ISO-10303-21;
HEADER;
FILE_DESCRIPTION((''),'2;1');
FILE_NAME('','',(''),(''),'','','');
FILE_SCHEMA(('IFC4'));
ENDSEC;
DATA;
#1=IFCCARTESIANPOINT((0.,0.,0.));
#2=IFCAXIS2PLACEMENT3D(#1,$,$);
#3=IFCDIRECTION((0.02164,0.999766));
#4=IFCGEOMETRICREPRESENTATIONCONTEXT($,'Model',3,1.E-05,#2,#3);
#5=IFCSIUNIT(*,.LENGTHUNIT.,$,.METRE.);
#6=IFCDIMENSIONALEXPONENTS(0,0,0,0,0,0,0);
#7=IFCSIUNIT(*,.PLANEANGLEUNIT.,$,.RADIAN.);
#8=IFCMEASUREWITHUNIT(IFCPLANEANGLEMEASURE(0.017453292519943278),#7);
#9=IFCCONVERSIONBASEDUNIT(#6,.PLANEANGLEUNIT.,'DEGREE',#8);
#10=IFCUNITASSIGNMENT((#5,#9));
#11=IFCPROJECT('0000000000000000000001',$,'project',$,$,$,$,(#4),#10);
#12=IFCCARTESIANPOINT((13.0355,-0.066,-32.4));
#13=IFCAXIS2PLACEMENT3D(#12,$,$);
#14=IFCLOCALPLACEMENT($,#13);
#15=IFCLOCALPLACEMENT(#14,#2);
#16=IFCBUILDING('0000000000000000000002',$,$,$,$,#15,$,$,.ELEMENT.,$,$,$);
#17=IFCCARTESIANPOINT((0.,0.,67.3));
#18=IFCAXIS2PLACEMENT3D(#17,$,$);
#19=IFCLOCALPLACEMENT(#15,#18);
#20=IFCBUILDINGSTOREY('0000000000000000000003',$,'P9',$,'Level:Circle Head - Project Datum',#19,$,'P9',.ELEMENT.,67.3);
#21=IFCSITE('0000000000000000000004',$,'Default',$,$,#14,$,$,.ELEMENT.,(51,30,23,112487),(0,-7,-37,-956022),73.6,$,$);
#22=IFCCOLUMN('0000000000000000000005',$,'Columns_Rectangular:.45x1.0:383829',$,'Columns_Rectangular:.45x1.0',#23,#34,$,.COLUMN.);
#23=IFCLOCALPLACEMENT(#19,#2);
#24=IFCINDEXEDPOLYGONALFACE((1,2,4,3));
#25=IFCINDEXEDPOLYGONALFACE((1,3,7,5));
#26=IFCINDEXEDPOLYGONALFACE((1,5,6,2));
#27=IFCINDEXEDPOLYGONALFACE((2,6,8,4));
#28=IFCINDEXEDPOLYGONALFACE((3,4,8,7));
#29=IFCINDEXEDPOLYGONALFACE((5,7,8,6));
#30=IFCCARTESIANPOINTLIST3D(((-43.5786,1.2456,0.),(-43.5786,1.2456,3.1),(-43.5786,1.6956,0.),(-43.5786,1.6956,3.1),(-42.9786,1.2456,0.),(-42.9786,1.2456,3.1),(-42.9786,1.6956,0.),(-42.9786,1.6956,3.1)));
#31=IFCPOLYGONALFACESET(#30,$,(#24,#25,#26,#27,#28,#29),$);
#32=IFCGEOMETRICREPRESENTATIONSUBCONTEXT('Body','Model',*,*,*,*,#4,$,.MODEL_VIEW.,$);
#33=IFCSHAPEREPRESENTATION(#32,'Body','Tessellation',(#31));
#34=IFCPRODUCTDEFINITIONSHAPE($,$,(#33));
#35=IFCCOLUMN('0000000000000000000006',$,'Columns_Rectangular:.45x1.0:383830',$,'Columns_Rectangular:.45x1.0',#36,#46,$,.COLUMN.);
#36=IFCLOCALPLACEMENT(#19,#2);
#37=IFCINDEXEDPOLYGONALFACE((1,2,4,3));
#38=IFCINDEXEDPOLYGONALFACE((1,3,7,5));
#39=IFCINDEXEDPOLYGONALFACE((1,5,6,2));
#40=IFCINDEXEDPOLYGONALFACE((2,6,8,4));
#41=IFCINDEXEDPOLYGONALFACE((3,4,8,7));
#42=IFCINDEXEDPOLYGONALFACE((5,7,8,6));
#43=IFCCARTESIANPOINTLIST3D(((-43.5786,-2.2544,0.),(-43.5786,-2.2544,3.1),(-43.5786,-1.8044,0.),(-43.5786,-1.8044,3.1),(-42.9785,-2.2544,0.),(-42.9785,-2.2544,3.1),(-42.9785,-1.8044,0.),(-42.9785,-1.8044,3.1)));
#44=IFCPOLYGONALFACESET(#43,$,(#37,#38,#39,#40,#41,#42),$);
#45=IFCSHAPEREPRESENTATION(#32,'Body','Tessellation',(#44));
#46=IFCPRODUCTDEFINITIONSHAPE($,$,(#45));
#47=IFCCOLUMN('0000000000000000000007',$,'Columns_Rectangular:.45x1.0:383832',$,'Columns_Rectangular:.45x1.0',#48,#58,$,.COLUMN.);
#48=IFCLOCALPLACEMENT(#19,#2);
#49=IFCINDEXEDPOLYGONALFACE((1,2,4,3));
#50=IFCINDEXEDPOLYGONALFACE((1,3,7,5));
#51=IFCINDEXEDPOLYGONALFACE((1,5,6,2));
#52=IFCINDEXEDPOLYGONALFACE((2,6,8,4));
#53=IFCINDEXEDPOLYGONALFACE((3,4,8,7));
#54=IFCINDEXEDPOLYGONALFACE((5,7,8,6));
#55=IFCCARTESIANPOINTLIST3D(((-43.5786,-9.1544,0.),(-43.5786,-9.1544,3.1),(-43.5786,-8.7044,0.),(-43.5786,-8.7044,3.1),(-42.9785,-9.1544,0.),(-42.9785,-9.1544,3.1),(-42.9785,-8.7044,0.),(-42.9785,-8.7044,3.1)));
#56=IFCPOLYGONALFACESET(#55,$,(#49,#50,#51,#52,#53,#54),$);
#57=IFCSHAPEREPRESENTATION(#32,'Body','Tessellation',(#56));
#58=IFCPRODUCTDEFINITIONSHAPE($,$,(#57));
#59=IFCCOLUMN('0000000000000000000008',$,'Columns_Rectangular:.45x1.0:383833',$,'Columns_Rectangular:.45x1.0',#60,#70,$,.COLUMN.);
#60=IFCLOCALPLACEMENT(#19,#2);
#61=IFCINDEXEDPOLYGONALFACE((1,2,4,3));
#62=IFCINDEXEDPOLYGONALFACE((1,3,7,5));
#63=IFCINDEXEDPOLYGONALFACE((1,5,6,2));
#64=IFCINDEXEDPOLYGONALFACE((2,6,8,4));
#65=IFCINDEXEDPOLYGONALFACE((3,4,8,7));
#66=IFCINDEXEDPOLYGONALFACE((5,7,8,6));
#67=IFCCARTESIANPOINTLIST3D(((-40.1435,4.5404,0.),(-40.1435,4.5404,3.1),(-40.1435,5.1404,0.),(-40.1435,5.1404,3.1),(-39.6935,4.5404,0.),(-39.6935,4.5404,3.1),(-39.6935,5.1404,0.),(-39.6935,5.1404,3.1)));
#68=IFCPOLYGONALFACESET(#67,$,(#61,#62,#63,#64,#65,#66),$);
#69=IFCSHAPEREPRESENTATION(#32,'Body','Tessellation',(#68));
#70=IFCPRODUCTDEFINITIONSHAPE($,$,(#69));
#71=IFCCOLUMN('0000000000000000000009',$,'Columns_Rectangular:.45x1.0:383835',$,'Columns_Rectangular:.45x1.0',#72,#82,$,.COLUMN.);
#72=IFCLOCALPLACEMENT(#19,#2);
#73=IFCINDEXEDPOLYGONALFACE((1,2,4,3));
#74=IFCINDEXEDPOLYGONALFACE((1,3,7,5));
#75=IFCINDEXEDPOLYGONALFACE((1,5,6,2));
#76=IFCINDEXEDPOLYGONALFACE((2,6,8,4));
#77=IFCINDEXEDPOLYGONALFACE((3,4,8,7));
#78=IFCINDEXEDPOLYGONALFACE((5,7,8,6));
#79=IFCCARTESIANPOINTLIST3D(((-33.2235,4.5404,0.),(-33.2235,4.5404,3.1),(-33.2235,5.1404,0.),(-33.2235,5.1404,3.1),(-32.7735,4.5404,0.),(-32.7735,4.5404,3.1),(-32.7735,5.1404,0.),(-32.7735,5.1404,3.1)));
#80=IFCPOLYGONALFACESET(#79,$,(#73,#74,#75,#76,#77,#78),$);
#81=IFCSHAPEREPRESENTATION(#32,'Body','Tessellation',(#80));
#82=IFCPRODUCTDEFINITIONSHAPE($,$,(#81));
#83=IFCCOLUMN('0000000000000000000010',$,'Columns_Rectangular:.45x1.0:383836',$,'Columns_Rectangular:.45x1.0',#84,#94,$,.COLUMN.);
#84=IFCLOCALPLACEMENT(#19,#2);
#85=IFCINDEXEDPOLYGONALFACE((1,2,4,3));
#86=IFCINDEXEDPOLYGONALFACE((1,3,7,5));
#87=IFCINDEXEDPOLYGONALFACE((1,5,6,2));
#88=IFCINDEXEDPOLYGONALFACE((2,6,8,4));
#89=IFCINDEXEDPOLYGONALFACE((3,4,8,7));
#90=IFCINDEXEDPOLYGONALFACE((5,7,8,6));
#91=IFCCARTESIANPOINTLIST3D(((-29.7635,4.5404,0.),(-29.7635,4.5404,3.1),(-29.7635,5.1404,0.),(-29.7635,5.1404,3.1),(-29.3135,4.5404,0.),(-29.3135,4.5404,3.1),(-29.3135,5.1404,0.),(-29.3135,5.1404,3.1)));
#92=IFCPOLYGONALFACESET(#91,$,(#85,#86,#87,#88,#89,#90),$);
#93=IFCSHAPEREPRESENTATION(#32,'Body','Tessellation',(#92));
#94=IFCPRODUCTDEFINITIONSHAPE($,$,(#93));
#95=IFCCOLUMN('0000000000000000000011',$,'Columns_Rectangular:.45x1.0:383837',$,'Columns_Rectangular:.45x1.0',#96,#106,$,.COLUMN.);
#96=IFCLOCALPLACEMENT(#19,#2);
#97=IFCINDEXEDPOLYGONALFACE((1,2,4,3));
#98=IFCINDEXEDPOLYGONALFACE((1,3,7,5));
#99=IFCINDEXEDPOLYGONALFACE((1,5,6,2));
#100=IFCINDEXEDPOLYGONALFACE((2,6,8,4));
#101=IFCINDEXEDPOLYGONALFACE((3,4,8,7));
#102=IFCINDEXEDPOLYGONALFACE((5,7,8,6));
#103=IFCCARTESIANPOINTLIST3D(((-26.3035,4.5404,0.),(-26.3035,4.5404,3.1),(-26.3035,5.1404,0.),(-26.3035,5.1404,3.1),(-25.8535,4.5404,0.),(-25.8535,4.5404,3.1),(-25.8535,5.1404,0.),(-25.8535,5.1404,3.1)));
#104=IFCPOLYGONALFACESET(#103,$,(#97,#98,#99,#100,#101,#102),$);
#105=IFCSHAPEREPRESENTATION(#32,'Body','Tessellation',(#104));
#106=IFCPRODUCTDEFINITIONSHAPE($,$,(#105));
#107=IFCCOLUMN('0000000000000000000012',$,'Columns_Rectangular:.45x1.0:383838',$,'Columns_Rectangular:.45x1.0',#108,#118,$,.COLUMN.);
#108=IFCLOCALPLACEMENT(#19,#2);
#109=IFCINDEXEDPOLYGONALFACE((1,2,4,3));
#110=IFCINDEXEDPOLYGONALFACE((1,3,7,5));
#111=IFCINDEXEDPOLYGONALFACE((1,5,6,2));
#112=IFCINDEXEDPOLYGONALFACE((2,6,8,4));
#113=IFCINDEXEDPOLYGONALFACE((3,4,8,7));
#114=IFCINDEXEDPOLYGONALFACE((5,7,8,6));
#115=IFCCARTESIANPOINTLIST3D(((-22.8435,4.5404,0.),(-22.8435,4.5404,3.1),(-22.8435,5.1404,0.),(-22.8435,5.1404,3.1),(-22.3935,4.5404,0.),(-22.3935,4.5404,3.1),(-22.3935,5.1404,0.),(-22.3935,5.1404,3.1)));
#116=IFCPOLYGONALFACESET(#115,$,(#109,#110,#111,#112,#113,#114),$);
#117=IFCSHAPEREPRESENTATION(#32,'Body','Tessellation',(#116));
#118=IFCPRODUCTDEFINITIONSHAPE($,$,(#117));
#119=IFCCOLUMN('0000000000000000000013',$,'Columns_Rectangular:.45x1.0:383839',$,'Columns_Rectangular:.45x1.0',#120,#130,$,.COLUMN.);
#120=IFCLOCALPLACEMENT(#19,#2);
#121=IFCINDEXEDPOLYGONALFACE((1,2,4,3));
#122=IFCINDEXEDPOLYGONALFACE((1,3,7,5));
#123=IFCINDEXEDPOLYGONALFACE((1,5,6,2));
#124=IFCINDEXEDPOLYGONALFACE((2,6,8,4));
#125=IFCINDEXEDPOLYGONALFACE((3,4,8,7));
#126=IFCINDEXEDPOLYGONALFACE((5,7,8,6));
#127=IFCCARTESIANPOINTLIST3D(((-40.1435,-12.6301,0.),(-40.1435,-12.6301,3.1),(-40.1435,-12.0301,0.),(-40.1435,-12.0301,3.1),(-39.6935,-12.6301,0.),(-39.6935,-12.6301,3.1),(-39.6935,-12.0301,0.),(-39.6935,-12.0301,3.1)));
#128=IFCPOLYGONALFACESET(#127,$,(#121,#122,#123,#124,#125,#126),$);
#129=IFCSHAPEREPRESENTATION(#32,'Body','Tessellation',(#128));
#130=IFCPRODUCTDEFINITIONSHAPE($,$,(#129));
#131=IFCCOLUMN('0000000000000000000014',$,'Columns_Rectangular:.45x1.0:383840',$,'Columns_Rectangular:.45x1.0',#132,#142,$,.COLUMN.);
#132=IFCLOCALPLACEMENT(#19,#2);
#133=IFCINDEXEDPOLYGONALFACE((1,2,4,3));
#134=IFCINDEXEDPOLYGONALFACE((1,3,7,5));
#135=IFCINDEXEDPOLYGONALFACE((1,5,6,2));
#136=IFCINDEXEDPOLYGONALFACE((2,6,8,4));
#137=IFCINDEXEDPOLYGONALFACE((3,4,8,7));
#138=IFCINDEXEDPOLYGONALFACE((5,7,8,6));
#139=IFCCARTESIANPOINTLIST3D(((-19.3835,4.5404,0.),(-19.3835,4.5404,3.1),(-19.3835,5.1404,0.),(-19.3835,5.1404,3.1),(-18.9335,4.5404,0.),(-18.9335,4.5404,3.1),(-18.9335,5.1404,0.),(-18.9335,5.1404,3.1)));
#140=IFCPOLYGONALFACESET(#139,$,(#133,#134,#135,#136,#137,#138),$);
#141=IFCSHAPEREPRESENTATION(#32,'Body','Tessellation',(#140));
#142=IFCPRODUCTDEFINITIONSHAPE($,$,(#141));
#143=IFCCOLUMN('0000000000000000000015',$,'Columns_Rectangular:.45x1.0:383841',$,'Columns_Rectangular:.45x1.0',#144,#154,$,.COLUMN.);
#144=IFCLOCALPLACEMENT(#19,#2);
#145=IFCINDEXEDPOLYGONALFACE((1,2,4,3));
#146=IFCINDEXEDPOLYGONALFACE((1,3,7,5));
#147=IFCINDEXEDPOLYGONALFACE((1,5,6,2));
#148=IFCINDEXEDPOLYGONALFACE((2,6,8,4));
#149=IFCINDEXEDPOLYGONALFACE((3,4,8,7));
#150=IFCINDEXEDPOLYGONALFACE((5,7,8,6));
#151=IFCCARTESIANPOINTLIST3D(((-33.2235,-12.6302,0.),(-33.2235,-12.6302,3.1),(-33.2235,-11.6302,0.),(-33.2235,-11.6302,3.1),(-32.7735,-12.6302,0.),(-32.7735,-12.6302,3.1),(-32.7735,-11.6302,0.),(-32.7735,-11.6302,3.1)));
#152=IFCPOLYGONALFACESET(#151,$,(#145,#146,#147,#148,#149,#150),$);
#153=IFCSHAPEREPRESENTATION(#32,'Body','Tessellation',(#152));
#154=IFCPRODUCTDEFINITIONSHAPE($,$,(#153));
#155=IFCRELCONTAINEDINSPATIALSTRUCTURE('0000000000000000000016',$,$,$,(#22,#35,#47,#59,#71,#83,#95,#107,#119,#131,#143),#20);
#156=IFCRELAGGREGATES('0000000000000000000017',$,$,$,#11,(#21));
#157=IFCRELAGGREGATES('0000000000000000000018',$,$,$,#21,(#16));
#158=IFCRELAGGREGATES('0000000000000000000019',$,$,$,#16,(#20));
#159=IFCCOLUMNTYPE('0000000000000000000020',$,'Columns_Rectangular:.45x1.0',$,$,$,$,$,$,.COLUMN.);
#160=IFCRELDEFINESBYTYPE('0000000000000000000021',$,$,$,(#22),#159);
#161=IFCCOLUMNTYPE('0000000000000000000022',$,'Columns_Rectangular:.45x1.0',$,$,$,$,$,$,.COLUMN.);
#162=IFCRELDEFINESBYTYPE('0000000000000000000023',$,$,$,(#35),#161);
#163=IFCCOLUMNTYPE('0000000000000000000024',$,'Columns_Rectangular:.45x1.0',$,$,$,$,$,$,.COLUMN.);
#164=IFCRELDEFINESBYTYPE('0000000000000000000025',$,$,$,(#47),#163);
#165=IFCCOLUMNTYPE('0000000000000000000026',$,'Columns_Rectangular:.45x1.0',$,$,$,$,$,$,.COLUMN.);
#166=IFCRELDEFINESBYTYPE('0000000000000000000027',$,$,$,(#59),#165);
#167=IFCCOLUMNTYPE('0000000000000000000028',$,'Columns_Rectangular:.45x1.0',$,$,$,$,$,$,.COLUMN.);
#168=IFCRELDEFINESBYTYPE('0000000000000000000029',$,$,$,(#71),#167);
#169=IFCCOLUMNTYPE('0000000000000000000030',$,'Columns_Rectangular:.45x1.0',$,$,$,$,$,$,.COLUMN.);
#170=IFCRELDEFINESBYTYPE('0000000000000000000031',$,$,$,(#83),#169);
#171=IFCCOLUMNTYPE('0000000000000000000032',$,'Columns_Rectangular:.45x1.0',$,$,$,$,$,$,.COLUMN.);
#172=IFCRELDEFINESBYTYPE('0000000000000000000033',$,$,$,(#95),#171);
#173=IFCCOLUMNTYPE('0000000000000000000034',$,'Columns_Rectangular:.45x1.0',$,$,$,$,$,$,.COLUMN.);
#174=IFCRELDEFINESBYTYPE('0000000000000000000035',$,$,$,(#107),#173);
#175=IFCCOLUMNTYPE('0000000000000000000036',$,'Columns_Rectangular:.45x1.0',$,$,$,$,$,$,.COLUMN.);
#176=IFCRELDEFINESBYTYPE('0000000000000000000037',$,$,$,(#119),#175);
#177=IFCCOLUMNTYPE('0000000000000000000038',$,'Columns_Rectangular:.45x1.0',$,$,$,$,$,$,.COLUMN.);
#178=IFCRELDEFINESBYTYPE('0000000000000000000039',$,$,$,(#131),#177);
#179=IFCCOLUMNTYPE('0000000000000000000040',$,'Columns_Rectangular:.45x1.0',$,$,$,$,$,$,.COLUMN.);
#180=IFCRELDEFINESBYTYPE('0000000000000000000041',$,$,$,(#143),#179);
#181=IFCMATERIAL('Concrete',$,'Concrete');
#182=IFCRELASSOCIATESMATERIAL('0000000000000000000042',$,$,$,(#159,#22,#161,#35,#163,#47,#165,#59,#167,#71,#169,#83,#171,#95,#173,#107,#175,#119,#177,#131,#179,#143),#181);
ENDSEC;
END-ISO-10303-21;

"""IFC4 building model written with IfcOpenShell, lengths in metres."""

from ifc_helpers import new_model, entity, si_unit, converted_unit, direction, frame, origin, place, context, subcontext, project, spatial, indexed_curve, outline, extrude, source, transform, mapped, material, type_object, type_shapes, element, save


model = new_model("IFC4")

# Units and contexts
model_context = context("Model", 3, precision=1e-05, world=origin(), true_north=direction((0.02164, 0.999766)))
body_context = subcontext(model_context, "Body", "Model", "MODEL_VIEW")
ifc_project = project(units=[si_unit("LENGTHUNIT", "METRE"), converted_unit("PLANEANGLEUNIT", "DEGREE", entity("IfcPlaneAngleMeasure", 0.017453292519943278), si_unit("PLANEANGLEUNIT", "RADIAN"), dimensions=[0, 0, 0, 0, 0, 0, 0])], contexts=[model_context])

# Site, building, storey
site_placement = place(None, frame((13.0355, -0.066, -32.4)))
site = spatial("IfcSite", under=ifc_project, at=site_placement, Name="Default", CompositionType="ELEMENT", RefLatitude=(51, 30, 23, 112487), RefLongitude=(0, -7, -37, -956022), RefElevation=73.6)
building_placement = place(site_placement, origin())
building = spatial("IfcBuilding", under=site, at=building_placement, CompositionType="ELEMENT")
storey_placement = place(building_placement, frame((0.0, 0.0, 67.3)))
storey = spatial("IfcBuildingStorey", under=building, at=storey_placement, Name="P9", ObjectType="Level:Circle Head - Project Datum", LongName="P9", CompositionType="ELEMENT", Elevation=67.3)

# Columns
ifc_material = material(Name="Concrete", Category="Concrete")
column_type_1 = type_object("IfcColumnType", Name="Columns_Rectangular:.45x1.0", PredefinedType="COLUMN", material=ifc_material)
shared_shape_1 = source(origin(), body_context, "Body", "SweptSolid", [
    extrude(outline(indexed_curve([(-0.3, -0.225), (0.3, -0.225), (0.3, 0.225), (-0.3, 0.225), (-0.3, -0.225)], self_intersect=False)), frame((-43.2786, 1.4706, 67.3)), (0.0, 0.0, 1.0), 3.1),
])
type_shapes(column_type_1, [shared_shape_1])
column_1_placement = place(storey_placement, frame((0.0, 0.0, -67.3)))
element("IfcColumn", 1, at=column_1_placement, inside=storey, type_object=column_type_1, material=ifc_material, Name="Columns_Rectangular:.45x1.0:383829", ObjectType="Columns_Rectangular:.45x1.0", PredefinedType="COLUMN", context=body_context, shape_type="MappedRepresentation", body=[
    mapped(shared_shape_1, transform((0.0, 0.0, 0.0), scale=1.0)),
])
column_type_2 = type_object("IfcColumnType", Name="Columns_Rectangular:.45x1.0", PredefinedType="COLUMN", material=ifc_material)
shared_shape_2 = source(origin(), body_context, "Body", "SweptSolid", [
    extrude(outline(indexed_curve([(-0.3, -0.225), (0.3, -0.225), (0.3, 0.225), (-0.3, 0.225), (-0.3, -0.225)], self_intersect=False)), frame((-43.2785, -2.0294, 67.3)), (0.0, 0.0, 1.0), 3.1),
])
type_shapes(column_type_2, [shared_shape_2])
column_2_placement = place(storey_placement, frame((0.0, 0.0, -67.3)))
element("IfcColumn", 2, at=column_2_placement, inside=storey, type_object=column_type_2, material=ifc_material, Name="Columns_Rectangular:.45x1.0:383830", ObjectType="Columns_Rectangular:.45x1.0", PredefinedType="COLUMN", context=body_context, shape_type="MappedRepresentation", body=[
    mapped(shared_shape_2, transform((0.0, 0.0, 0.0), scale=1.0)),
])
column_type_3 = type_object("IfcColumnType", Name="Columns_Rectangular:.45x1.0", PredefinedType="COLUMN", material=ifc_material)
shared_shape_3 = source(origin(), body_context, "Body", "SweptSolid", [
    extrude(outline(indexed_curve([(-0.3, -0.225), (0.3, -0.225), (0.3, 0.225), (-0.3, 0.225), (-0.3, -0.225)], self_intersect=False)), frame((-43.2785, -8.9294, 67.3)), (0.0, 0.0, 1.0), 3.1),
])
type_shapes(column_type_3, [shared_shape_3])
column_3_placement = place(storey_placement, frame((0.0, 0.0, -67.3)))
element("IfcColumn", 3, at=column_3_placement, inside=storey, type_object=column_type_3, material=ifc_material, Name="Columns_Rectangular:.45x1.0:383832", ObjectType="Columns_Rectangular:.45x1.0", PredefinedType="COLUMN", context=body_context, shape_type="MappedRepresentation", body=[
    mapped(shared_shape_3, transform((0.0, 0.0, 0.0), scale=1.0)),
])
column_type_4 = type_object("IfcColumnType", Name="Columns_Rectangular:.45x1.0", PredefinedType="COLUMN", material=ifc_material)
shared_shape_4 = source(origin(), body_context, "Body", "SweptSolid", [
    extrude(outline(indexed_curve([(-0.3, -0.225), (0.3, -0.225), (0.3, 0.225), (-0.3, 0.225), (-0.3, -0.225)], self_intersect=False)), frame((-39.9185, 4.8404, 67.3), z_axis=(0.0, 0.0, 1.0), x_axis=(0.0, -1.0, 0.0)), (0.0, 0.0, 1.0), 3.1),
])
type_shapes(column_type_4, [shared_shape_4])
column_4_placement = place(storey_placement, frame((0.0, 0.0, -67.3)))
element("IfcColumn", 4, at=column_4_placement, inside=storey, type_object=column_type_4, material=ifc_material, Name="Columns_Rectangular:.45x1.0:383833", ObjectType="Columns_Rectangular:.45x1.0", PredefinedType="COLUMN", context=body_context, shape_type="MappedRepresentation", body=[
    mapped(shared_shape_4, transform((0.0, 0.0, 0.0), scale=1.0)),
])
column_type_5 = type_object("IfcColumnType", Name="Columns_Rectangular:.45x1.0", PredefinedType="COLUMN", material=ifc_material)
shared_shape_5 = source(origin(), body_context, "Body", "SweptSolid", [
    extrude(outline(indexed_curve([(-0.3, -0.225), (0.3, -0.225), (0.3, 0.225), (-0.3, 0.225), (-0.3, -0.225)], self_intersect=False)), frame((-32.9985, 4.8404, 67.3), z_axis=(0.0, 0.0, 1.0), x_axis=(0.0, -1.0, 0.0)), (0.0, 0.0, 1.0), 3.1),
])
type_shapes(column_type_5, [shared_shape_5])
column_5_placement = place(storey_placement, frame((0.0, 0.0, -67.3)))
element("IfcColumn", 5, at=column_5_placement, inside=storey, type_object=column_type_5, material=ifc_material, Name="Columns_Rectangular:.45x1.0:383835", ObjectType="Columns_Rectangular:.45x1.0", PredefinedType="COLUMN", context=body_context, shape_type="MappedRepresentation", body=[
    mapped(shared_shape_5, transform((0.0, 0.0, 0.0), scale=1.0)),
])
column_type_6 = type_object("IfcColumnType", Name="Columns_Rectangular:.45x1.0", PredefinedType="COLUMN", material=ifc_material)
shared_shape_6 = source(origin(), body_context, "Body", "SweptSolid", [
    extrude(outline(indexed_curve([(-0.3, -0.225), (0.3, -0.225), (0.3, 0.225), (-0.3, 0.225), (-0.3, -0.225)], self_intersect=False)), frame((-29.5385, 4.8404, 67.3), z_axis=(0.0, 0.0, 1.0), x_axis=(0.0, -1.0, 0.0)), (0.0, 0.0, 1.0), 3.1),
])
type_shapes(column_type_6, [shared_shape_6])
column_6_placement = place(storey_placement, frame((0.0, 0.0, -67.3)))
element("IfcColumn", 6, at=column_6_placement, inside=storey, type_object=column_type_6, material=ifc_material, Name="Columns_Rectangular:.45x1.0:383836", ObjectType="Columns_Rectangular:.45x1.0", PredefinedType="COLUMN", context=body_context, shape_type="MappedRepresentation", body=[
    mapped(shared_shape_6, transform((0.0, 0.0, 0.0), scale=1.0)),
])
column_type_7 = type_object("IfcColumnType", Name="Columns_Rectangular:.45x1.0", PredefinedType="COLUMN", material=ifc_material)
shared_shape_7 = source(origin(), body_context, "Body", "SweptSolid", [
    extrude(outline(indexed_curve([(-0.3, -0.225), (0.3, -0.225), (0.3, 0.225), (-0.3, 0.225), (-0.3, -0.225)], self_intersect=False)), frame((-26.0785, 4.8404, 67.3), z_axis=(0.0, 0.0, 1.0), x_axis=(0.0, -1.0, 0.0)), (0.0, 0.0, 1.0), 3.1),
])
type_shapes(column_type_7, [shared_shape_7])
column_7_placement = place(storey_placement, frame((0.0, 0.0, -67.3)))
element("IfcColumn", 7, at=column_7_placement, inside=storey, type_object=column_type_7, material=ifc_material, Name="Columns_Rectangular:.45x1.0:383837", ObjectType="Columns_Rectangular:.45x1.0", PredefinedType="COLUMN", context=body_context, shape_type="MappedRepresentation", body=[
    mapped(shared_shape_7, transform((0.0, 0.0, 0.0), scale=1.0)),
])
column_type_8 = type_object("IfcColumnType", Name="Columns_Rectangular:.45x1.0", PredefinedType="COLUMN", material=ifc_material)
shared_shape_8 = source(origin(), body_context, "Body", "SweptSolid", [
    extrude(outline(indexed_curve([(-0.3, -0.225), (0.3, -0.225), (0.3, 0.225), (-0.3, 0.225), (-0.3, -0.225)], self_intersect=False)), frame((-22.6185, 4.8404, 67.3), z_axis=(0.0, 0.0, 1.0), x_axis=(0.0, -1.0, 0.0)), (0.0, 0.0, 1.0), 3.1),
])
type_shapes(column_type_8, [shared_shape_8])
column_8_placement = place(storey_placement, frame((0.0, 0.0, -67.3)))
element("IfcColumn", 8, at=column_8_placement, inside=storey, type_object=column_type_8, material=ifc_material, Name="Columns_Rectangular:.45x1.0:383838", ObjectType="Columns_Rectangular:.45x1.0", PredefinedType="COLUMN", context=body_context, shape_type="MappedRepresentation", body=[
    mapped(shared_shape_8, transform((0.0, 0.0, 0.0), scale=1.0)),
])
column_type_9 = type_object("IfcColumnType", Name="Columns_Rectangular:.45x1.0", PredefinedType="COLUMN", material=ifc_material)
shared_shape_9 = source(origin(), body_context, "Body", "SweptSolid", [
    extrude(outline(indexed_curve([(-0.3, -0.225), (0.3, -0.225), (0.3, 0.225), (-0.3, 0.225), (-0.3, -0.225)], self_intersect=False)), frame((-39.9185, -12.3301, 67.3), z_axis=(0.0, 0.0, 1.0), x_axis=(0.000011, 1.0, 0.0)), (0.0, 0.0, 1.0), 3.1),
])
type_shapes(column_type_9, [shared_shape_9])
column_9_placement = place(storey_placement, frame((0.0, 0.0, -67.3)))
element("IfcColumn", 9, at=column_9_placement, inside=storey, type_object=column_type_9, material=ifc_material, Name="Columns_Rectangular:.45x1.0:383839", ObjectType="Columns_Rectangular:.45x1.0", PredefinedType="COLUMN", context=body_context, shape_type="MappedRepresentation", body=[
    mapped(shared_shape_9, transform((0.0, 0.0, 0.0), scale=1.0)),
])
column_type_10 = type_object("IfcColumnType", Name="Columns_Rectangular:.45x1.0", PredefinedType="COLUMN", material=ifc_material)
shared_shape_10 = source(origin(), body_context, "Body", "SweptSolid", [
    extrude(outline(indexed_curve([(-0.3, -0.225), (0.3, -0.225), (0.3, 0.225), (-0.3, 0.225), (-0.3, -0.225)], self_intersect=False)), frame((-19.1585, 4.8404, 67.3), z_axis=(0.0, 0.0, 1.0), x_axis=(0.0, -1.0, 0.0)), (0.0, 0.0, 1.0), 3.1),
])
type_shapes(column_type_10, [shared_shape_10])
column_10_placement = place(storey_placement, frame((0.0, 0.0, -67.3)))
element("IfcColumn", 10, at=column_10_placement, inside=storey, type_object=column_type_10, material=ifc_material, Name="Columns_Rectangular:.45x1.0:383840", ObjectType="Columns_Rectangular:.45x1.0", PredefinedType="COLUMN", context=body_context, shape_type="MappedRepresentation", body=[
    mapped(shared_shape_10, transform((0.0, 0.0, 0.0), scale=1.0)),
])
column_type_11 = type_object("IfcColumnType", Name="Columns_Rectangular:.45x1.0", PredefinedType="COLUMN", material=ifc_material)
shared_shape_11 = source(origin(), body_context, "Body", "SweptSolid", [
    extrude(outline(indexed_curve([(-0.5, -0.225), (0.5, -0.225), (0.5, 0.225), (-0.5, 0.225), (-0.5, -0.225)], self_intersect=False)), frame((-32.9985, -12.1302, 67.3), z_axis=(0.0, 0.0, 1.0), x_axis=(0.000011, 1.0, 0.0)), (0.0, 0.0, 1.0), 3.1),
])
type_shapes(column_type_11, [shared_shape_11])
column_11_placement = place(storey_placement, frame((0.0, 0.0, -67.3)))
element("IfcColumn", 11, at=column_11_placement, inside=storey, type_object=column_type_11, material=ifc_material, Name="Columns_Rectangular:.45x1.0:383841", ObjectType="Columns_Rectangular:.45x1.0", PredefinedType="COLUMN", context=body_context, shape_type="MappedRepresentation", body=[
    mapped(shared_shape_11, transform((0.0, 0.0, 0.0), scale=1.0)),
])

save(model, "model.ifc")
